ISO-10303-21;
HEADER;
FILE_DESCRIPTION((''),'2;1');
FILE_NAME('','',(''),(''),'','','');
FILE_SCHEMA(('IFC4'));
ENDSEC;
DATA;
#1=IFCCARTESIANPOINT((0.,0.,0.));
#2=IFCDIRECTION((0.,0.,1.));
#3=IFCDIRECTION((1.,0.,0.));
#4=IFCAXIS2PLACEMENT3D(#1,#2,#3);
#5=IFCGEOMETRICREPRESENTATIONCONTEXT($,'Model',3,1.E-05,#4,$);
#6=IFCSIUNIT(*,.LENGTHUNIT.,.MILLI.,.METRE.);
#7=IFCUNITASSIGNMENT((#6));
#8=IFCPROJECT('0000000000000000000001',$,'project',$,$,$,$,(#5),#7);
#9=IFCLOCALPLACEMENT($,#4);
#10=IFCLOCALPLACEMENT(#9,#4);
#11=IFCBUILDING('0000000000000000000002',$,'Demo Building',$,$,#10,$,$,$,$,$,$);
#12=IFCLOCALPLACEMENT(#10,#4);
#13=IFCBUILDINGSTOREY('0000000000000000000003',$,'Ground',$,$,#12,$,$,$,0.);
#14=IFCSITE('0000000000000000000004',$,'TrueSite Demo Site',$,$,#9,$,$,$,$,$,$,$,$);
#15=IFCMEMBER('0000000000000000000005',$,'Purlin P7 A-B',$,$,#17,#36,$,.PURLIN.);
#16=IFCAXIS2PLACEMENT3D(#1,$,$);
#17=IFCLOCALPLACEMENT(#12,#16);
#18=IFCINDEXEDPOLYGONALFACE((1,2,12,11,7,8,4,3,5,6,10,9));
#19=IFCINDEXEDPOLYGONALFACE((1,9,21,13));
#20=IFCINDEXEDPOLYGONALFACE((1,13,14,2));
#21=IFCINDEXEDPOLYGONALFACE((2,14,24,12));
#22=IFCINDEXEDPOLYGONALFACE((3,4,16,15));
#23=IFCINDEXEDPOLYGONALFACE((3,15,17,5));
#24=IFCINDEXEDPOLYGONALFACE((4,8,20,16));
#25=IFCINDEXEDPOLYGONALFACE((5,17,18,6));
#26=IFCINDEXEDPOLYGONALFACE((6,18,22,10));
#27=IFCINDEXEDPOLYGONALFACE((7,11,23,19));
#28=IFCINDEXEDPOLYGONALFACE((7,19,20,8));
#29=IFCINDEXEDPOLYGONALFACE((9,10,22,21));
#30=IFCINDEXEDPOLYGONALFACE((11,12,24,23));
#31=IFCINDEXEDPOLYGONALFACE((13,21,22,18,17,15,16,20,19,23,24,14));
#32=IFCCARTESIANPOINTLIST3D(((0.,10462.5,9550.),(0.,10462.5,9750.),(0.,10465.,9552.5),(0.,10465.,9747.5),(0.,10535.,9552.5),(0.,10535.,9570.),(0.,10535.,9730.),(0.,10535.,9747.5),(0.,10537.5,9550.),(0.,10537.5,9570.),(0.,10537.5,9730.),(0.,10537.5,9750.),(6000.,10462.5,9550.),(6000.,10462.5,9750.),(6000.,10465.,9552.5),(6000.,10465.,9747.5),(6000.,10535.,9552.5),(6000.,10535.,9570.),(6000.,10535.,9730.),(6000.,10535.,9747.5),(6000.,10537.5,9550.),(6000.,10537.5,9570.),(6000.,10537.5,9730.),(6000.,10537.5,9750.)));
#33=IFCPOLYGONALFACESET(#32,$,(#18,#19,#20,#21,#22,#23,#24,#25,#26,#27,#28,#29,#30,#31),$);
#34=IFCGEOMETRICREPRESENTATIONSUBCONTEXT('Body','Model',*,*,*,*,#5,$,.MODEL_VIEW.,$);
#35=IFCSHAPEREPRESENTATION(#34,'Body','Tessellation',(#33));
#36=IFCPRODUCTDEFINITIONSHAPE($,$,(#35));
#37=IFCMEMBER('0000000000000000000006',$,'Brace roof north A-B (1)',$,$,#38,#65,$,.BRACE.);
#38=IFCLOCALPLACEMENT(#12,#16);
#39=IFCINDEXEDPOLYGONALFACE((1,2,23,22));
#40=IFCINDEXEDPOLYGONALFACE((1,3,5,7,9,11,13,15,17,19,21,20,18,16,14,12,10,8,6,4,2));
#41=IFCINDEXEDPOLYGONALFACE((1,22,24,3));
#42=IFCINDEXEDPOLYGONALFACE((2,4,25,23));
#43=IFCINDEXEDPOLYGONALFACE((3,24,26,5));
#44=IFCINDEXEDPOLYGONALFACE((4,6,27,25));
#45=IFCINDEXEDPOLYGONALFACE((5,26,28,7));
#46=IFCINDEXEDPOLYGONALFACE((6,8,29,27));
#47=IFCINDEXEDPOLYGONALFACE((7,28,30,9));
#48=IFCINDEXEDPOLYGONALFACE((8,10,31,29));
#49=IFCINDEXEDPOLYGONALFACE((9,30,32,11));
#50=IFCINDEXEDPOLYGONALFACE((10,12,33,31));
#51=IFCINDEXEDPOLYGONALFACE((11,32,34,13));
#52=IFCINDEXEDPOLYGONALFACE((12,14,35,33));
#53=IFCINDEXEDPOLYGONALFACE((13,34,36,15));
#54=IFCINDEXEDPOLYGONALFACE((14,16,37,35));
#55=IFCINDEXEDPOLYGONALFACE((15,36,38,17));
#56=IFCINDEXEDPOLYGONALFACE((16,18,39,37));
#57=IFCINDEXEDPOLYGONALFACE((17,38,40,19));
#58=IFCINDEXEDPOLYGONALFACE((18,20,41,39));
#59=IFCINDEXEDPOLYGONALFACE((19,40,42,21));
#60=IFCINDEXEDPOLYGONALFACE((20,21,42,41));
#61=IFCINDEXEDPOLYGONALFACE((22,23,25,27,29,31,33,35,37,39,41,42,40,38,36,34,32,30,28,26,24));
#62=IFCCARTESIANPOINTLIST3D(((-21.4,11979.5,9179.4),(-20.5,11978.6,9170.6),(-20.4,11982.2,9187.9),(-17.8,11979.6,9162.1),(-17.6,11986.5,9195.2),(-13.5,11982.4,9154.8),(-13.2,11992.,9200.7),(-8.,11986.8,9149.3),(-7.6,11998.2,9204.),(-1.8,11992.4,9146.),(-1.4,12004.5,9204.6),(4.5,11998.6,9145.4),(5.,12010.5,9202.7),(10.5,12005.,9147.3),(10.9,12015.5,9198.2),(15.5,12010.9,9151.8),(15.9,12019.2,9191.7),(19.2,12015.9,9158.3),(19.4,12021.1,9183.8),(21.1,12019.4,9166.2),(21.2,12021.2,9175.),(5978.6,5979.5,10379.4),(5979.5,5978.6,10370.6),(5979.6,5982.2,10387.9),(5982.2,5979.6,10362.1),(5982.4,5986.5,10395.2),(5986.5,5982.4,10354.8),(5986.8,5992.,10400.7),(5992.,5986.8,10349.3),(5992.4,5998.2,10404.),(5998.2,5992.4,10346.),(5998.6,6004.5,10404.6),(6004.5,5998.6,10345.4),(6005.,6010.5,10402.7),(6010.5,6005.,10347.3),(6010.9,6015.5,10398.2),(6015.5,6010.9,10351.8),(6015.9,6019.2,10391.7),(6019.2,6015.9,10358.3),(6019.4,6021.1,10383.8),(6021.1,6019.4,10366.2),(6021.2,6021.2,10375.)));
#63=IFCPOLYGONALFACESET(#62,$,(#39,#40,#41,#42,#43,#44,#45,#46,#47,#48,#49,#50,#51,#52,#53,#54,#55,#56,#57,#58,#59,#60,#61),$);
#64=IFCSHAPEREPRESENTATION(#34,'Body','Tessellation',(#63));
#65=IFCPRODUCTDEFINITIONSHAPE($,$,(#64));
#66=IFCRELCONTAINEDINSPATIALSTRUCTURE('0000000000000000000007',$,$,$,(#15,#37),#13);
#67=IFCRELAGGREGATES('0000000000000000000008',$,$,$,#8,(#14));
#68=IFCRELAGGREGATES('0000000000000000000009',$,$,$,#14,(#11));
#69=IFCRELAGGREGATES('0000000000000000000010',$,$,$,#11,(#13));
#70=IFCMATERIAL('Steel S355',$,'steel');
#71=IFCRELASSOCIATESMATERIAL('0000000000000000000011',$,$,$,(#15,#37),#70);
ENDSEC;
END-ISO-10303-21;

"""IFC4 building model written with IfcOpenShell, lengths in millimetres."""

from ifc_helpers import new_model, si_unit, frame, origin_with_axes, place, context, subcontext, project, spatial, circle, c_section, extrude, material, element, save


model = new_model("IFC4")

# Units and contexts
model_context = context("Model", 3, precision=1e-05, world=origin_with_axes())
body_context = subcontext(model_context, "Body", "Model", "MODEL_VIEW")
ifc_project = project(units=[si_unit("LENGTHUNIT", "METRE", prefix="MILLI")], contexts=[model_context])

# Site, building, storey
site_placement = place(None, origin_with_axes())
site = spatial("IfcSite", under=ifc_project, at=site_placement, Name="TrueSite Demo Site")
building_placement = place(site_placement, origin_with_axes())
building = spatial("IfcBuilding", under=site, at=building_placement, Name="Demo Building")
storey_placement = place(building_placement, origin_with_axes())
storey = spatial("IfcBuildingStorey", under=building, at=storey_placement, Name="Ground", Elevation=0.0)

# Members
ifc_material = material(Name="Steel S355", Category="steel")
for number, where, z_axis, x_axis, name in (
    (1, (0.0, 10500.0, 9650.0), (1.0, 0.0, 0.0), (0.0, 1.0, 0.0), "Purlin P7 A-B"),
):
    element("IfcMember", number, at=place(storey_placement, frame(where, z_axis=z_axis, x_axis=x_axis)), inside=storey, material=ifc_material, Name=name, PredefinedType="PURLIN", context=body_context, shape_type="SweptSolid", body=[
        extrude(c_section(Depth=200.0, Width=75.0, WallThickness=2.5, Girth=20.0), origin_with_axes(), (0.0, 0.0, 1.0), 6000.0),
    ])
member_1_placement = place(storey_placement, frame((0.0, 12000.0, 9175.0), z_axis=(0.70014, -0.70014, 0.140028), x_axis=(0.707107, 0.707107, 0.0)))
element("IfcMember", 2, at=member_1_placement, inside=storey, material=ifc_material, Name="Brace roof north A-B (1)", PredefinedType="BRACE", context=body_context, shape_type="SweptSolid", body=[
    extrude(circle(Radius=30.0), origin_with_axes(), (0.0, 0.0, 1.0), 8569.7),
])

save(model, "model.ifc")
